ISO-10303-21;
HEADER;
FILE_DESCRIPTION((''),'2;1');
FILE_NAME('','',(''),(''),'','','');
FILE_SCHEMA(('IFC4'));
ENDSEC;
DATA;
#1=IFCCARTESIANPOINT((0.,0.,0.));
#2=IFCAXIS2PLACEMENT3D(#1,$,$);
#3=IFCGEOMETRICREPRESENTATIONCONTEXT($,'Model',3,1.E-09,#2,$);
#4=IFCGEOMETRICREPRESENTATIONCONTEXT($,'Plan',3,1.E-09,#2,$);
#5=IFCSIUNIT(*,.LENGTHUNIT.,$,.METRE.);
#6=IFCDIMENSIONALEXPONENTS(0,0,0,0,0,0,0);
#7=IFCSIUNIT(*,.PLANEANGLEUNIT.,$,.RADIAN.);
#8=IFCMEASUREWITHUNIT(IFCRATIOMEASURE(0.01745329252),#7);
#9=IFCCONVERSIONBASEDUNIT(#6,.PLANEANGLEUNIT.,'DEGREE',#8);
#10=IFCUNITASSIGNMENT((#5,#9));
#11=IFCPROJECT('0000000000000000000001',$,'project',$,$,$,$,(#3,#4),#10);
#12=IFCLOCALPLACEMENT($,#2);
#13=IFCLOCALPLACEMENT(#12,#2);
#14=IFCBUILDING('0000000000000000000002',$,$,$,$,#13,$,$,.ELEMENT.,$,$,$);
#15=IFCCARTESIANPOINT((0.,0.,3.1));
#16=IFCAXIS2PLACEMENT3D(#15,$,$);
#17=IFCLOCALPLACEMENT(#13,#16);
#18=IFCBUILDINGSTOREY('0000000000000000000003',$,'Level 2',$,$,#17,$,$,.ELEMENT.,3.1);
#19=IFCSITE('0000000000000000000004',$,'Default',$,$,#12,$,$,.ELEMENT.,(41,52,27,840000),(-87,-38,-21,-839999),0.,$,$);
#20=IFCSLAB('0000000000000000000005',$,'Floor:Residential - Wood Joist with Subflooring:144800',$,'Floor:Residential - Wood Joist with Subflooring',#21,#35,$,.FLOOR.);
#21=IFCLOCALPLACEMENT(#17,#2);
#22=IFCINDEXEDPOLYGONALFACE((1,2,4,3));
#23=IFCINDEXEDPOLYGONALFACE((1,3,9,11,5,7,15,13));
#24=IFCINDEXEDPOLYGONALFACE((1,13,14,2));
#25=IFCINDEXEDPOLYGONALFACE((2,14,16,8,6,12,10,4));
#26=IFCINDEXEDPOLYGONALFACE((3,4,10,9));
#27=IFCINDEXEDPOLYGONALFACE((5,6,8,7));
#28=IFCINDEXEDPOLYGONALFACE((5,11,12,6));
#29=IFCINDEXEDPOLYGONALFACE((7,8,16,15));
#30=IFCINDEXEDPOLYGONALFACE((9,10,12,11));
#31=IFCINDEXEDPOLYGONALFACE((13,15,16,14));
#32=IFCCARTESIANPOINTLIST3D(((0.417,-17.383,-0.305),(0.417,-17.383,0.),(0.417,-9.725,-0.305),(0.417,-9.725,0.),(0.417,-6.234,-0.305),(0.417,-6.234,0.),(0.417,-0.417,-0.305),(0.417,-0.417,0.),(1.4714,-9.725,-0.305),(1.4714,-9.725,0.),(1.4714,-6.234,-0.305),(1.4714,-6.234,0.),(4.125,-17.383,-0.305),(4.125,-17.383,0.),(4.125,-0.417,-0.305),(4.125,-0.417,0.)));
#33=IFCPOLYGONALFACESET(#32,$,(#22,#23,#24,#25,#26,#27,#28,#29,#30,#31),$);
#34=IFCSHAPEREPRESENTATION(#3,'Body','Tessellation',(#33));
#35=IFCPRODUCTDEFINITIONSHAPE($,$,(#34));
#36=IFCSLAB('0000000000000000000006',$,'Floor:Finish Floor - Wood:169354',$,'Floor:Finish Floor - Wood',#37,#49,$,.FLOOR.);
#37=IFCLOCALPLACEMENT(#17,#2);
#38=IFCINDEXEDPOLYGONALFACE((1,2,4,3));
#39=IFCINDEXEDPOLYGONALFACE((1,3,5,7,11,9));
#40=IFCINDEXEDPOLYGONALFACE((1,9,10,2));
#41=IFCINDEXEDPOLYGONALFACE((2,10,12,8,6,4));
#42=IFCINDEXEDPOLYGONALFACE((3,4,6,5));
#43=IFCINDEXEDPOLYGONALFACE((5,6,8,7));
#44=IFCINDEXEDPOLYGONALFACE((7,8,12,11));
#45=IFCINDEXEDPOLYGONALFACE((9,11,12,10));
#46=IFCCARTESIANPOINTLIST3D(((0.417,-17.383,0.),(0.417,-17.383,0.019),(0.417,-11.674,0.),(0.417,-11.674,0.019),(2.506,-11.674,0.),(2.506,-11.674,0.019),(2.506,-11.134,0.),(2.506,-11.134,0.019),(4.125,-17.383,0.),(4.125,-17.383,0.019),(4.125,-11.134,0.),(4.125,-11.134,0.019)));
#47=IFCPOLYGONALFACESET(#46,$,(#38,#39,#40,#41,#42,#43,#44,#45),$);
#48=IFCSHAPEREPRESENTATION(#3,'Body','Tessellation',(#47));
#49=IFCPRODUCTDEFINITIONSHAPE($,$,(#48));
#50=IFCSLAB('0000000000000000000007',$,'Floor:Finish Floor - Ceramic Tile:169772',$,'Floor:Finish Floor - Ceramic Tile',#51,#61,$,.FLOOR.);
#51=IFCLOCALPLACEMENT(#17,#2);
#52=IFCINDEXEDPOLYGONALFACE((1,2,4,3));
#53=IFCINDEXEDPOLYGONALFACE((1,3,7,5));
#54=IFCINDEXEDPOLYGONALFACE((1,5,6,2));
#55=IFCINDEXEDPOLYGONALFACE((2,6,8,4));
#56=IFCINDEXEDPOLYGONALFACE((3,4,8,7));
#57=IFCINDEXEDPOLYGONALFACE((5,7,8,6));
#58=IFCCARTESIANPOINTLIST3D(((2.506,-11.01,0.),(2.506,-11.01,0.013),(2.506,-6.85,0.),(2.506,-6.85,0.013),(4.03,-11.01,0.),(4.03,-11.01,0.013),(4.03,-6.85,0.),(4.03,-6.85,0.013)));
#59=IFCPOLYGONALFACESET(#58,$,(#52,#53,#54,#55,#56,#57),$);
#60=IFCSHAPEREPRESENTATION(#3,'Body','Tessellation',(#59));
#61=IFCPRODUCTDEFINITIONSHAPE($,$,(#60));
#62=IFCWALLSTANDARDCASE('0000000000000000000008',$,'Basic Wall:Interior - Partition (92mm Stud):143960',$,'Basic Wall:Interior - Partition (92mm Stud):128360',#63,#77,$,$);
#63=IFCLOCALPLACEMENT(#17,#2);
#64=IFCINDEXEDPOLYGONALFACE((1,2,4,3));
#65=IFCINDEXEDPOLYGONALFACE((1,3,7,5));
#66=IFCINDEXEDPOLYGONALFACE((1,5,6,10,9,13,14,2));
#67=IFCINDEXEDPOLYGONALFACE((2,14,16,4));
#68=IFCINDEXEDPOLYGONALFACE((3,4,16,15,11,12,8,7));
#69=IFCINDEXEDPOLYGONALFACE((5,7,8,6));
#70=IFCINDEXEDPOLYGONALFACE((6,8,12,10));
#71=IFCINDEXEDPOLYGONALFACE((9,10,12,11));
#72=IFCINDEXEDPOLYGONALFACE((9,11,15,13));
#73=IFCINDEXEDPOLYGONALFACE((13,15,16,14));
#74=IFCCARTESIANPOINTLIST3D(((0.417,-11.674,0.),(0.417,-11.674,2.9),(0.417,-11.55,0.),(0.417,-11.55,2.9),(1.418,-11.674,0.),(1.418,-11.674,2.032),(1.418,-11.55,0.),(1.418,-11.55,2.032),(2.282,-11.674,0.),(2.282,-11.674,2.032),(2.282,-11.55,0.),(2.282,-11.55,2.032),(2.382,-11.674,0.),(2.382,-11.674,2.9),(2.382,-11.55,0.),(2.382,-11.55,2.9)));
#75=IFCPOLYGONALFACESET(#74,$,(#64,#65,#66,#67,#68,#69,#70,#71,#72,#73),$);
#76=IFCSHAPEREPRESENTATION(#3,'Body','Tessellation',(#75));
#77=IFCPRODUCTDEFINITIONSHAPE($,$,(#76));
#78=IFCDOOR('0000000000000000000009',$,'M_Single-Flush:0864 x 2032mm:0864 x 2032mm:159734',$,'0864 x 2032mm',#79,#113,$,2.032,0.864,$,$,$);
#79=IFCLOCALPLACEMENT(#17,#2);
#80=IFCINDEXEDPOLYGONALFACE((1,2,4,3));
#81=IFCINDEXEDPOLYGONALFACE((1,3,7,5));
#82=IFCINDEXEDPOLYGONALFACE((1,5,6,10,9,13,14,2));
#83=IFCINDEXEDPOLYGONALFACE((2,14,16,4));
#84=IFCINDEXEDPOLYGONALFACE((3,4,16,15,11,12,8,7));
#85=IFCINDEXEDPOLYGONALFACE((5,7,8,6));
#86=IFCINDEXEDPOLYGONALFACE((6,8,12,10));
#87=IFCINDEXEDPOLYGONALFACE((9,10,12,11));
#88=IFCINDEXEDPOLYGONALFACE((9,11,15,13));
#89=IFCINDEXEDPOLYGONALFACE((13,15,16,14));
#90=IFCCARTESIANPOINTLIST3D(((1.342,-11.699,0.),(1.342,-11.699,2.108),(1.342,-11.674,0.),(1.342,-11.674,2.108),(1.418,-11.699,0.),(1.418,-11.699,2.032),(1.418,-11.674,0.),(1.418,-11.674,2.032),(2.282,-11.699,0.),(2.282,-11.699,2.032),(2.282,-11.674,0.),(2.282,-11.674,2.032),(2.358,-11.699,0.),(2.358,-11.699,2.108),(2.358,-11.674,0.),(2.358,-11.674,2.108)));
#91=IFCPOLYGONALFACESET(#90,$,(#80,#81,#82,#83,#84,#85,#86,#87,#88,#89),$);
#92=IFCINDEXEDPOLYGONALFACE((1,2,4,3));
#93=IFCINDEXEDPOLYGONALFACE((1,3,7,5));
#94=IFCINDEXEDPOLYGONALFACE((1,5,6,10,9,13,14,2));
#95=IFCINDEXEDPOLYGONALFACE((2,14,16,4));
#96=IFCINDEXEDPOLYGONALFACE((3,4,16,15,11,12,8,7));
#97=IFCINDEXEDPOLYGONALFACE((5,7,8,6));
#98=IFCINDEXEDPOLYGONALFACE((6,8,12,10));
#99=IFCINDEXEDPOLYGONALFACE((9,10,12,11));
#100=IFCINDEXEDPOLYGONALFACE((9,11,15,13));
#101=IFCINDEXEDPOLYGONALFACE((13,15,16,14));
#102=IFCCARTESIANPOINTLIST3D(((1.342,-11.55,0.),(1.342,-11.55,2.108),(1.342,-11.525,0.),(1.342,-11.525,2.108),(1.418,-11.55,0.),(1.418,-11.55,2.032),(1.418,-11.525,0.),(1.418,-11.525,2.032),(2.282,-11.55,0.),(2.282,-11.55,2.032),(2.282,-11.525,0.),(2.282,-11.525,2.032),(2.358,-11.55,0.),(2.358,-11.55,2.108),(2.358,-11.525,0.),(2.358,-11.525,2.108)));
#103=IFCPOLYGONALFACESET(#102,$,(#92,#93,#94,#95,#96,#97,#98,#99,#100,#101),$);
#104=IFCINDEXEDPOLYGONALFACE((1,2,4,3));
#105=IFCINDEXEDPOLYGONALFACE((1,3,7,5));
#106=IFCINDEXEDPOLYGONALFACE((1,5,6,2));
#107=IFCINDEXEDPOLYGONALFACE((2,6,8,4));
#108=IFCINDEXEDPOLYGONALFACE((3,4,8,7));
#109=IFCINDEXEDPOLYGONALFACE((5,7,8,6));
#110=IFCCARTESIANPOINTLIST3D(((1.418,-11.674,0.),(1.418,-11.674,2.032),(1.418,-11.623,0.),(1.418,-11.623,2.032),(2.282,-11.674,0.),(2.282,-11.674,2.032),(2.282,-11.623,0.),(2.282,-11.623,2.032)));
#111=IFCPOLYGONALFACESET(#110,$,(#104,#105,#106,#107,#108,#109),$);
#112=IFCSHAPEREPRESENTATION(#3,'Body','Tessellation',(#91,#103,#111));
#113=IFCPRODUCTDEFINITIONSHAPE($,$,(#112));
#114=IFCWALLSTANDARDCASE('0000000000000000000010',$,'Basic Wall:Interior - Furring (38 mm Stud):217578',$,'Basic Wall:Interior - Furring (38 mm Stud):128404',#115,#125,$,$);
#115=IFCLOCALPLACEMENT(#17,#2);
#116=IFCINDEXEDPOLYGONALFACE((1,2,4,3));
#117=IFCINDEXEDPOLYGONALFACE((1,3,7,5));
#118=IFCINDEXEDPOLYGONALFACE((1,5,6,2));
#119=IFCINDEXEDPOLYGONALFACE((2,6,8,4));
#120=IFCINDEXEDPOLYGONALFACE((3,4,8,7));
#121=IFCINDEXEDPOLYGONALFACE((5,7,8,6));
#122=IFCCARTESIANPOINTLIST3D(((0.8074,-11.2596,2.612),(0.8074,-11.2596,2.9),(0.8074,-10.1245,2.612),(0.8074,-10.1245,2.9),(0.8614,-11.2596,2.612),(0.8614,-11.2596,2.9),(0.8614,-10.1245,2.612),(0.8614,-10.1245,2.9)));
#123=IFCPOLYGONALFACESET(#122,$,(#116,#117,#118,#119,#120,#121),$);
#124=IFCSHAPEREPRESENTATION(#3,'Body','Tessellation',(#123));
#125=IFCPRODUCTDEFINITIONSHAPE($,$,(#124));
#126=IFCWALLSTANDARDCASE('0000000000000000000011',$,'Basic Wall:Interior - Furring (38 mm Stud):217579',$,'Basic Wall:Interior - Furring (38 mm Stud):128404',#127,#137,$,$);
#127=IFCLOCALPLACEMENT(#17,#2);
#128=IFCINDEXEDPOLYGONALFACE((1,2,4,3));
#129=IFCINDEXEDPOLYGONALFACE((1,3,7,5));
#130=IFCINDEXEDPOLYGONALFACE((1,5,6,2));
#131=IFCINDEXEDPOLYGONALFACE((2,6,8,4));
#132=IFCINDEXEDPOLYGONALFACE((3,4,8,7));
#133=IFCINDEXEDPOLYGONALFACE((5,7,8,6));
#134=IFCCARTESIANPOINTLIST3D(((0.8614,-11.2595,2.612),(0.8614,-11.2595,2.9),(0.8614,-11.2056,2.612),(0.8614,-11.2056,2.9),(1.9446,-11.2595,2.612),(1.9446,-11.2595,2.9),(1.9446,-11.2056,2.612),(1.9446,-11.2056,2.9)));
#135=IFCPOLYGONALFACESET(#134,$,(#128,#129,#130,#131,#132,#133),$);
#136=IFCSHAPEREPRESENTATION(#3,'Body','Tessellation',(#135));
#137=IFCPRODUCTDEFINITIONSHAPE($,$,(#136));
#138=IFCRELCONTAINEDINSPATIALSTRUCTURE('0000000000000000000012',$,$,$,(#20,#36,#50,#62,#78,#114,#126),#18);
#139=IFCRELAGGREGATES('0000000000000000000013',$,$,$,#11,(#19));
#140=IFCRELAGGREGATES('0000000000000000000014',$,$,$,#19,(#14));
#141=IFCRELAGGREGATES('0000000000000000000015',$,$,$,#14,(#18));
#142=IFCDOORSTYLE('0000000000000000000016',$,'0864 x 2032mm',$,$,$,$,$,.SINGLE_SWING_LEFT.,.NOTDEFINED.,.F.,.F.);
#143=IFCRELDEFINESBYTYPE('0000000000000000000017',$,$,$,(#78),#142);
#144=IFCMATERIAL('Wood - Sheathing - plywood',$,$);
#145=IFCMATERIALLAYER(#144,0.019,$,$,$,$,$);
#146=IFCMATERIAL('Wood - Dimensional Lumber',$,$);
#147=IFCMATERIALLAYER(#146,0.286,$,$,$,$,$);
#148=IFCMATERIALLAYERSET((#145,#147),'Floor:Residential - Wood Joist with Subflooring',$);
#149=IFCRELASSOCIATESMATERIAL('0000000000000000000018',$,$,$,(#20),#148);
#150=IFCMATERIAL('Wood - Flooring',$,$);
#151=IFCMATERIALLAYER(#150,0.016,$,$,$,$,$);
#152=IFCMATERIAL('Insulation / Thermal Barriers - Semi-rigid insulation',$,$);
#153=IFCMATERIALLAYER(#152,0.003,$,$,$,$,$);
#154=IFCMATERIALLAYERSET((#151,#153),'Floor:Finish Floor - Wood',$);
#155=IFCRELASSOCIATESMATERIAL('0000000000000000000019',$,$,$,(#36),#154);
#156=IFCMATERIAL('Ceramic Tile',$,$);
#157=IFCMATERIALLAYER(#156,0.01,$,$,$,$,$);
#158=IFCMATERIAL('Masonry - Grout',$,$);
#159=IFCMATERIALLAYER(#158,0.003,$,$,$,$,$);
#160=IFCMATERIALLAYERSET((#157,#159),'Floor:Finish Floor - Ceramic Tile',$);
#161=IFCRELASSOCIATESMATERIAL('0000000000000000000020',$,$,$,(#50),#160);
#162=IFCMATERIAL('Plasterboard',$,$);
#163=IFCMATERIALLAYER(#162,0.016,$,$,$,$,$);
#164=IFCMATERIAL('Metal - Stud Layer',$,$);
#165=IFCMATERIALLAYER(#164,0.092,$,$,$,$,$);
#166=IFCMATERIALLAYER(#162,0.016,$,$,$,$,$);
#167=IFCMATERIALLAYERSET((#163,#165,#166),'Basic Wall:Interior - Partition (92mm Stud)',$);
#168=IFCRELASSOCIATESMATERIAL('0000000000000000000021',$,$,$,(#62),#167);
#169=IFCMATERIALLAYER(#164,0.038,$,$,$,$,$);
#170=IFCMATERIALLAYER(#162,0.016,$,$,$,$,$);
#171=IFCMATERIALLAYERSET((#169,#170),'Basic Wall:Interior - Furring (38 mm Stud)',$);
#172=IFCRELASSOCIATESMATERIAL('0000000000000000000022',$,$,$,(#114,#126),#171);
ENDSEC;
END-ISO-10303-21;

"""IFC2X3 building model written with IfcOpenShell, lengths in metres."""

from ifc_helpers import new_model, entity, si_unit, converted_unit, frame, frame_2d, origin, origin_2d_with_axis, place, context, project, spatial, polyline, rectangle, outline, extrude, source, transform, mapped, material, layer, layer_set, layer_usage, type_object, type_shapes, element, fill, save


model = new_model("IFC2X3")

# Units and contexts
model_context = context("Model", 3, precision=1e-09, world=origin())
plan_context = context("Plan", 3, precision=1e-09, world=origin())
ifc_project = project(units=[si_unit("LENGTHUNIT", "METRE"), converted_unit("PLANEANGLEUNIT", "DEGREE", entity("IfcRatioMeasure", 0.01745329252), si_unit("PLANEANGLEUNIT", "RADIAN"), dimensions=[0, 0, 0, 0, 0, 0, 0])], contexts=[model_context, plan_context])

# Site, building, storey
site_placement = place(None, origin())
site = spatial("IfcSite", under=ifc_project, at=site_placement, Name="Default", CompositionType="ELEMENT", RefLatitude=(41, 52, 27, 840000), RefLongitude=(-87, -38, -21, -839999), RefElevation=0.0)
building_placement = place(site_placement, origin())
building = spatial("IfcBuilding", under=site, at=building_placement, CompositionType="ELEMENT")
storey_placement = place(building_placement, frame((0.0, 0.0, 3.1)))
storey = spatial("IfcBuildingStorey", under=building, at=storey_placement, Name="Level 2", CompositionType="ELEMENT", Elevation=3.1)

# Slabs
ifc_material_1 = material(Name="Wood - Sheathing - plywood")
ifc_layer_1 = layer(ifc_material_1, 0.019)
ifc_material_2 = material(Name="Wood - Dimensional Lumber")
ifc_layer_2 = layer(ifc_material_2, 0.286)
ifc_layer_set_1 = layer_set([ifc_layer_1, ifc_layer_2], Name="Floor:Residential - Wood Joist with Subflooring")
ifc_layer_usage_1 = layer_usage(ifc_layer_set_1, "AXIS3", "POSITIVE", 0.0)
slab_1_placement = place(storey_placement, frame((0.417, -17.383, -0.305)))
element("IfcSlab", 1, at=slab_1_placement, inside=storey, material=ifc_layer_usage_1, Name="Floor:Residential - Wood Joist with Subflooring:144800", ObjectType="Floor:Residential - Wood Joist with Subflooring", PredefinedType="FLOOR", context=model_context, shape_type="SweptSolid", body=[
    extrude(outline(polyline([(-1.854, 8.483), (-1.854, -8.483), (1.854, -8.483), (1.854, -0.825), (0.7996, -0.825), (0.7996, 2.666), (1.854, 2.666), (1.854, 8.483), (-1.854, 8.483)])), frame((1.854, 8.483, 0.305), z_axis=(0.0, 0.0, -1.0), x_axis=(-1.0, 0.0, 0.0)), (0.0, 0.0, 1.0), 0.305),
])
ifc_material_3 = material(Name="Wood - Flooring")
ifc_layer_3 = layer(ifc_material_3, 0.016)
ifc_material_4 = material(Name="Insulation / Thermal Barriers - Semi-rigid insulation")
ifc_layer_4 = layer(ifc_material_4, 0.003)
ifc_layer_set_2 = layer_set([ifc_layer_3, ifc_layer_4], Name="Floor:Finish Floor - Wood")
ifc_layer_usage_2 = layer_usage(ifc_layer_set_2, "AXIS3", "POSITIVE", 0.0)
slab_2_placement = place(storey_placement, frame((0.417, -17.383, 0.0)))
element("IfcSlab", 2, at=slab_2_placement, inside=storey, material=ifc_layer_usage_2, Name="Floor:Finish Floor - Wood:169354", ObjectType="Floor:Finish Floor - Wood", PredefinedType="FLOOR", context=model_context, shape_type="SweptSolid", body=[
    extrude(outline(polyline([(-1.854, -3.1245), (1.854, -3.1245), (1.854, 2.5845), (-0.235, 2.5845), (-0.235, 3.1245), (-1.854, 3.1245), (-1.854, -3.1245)])), frame((1.854, 3.1245, 0.019), z_axis=(0.0, 0.0, -1.0), x_axis=(-1.0, 0.0, 0.0)), (0.0, 0.0, 1.0), 0.019),
])
ifc_material_5 = material(Name="Ceramic Tile")
ifc_layer_5 = layer(ifc_material_5, 0.01)
ifc_material_6 = material(Name="Masonry - Grout")
ifc_layer_6 = layer(ifc_material_6, 0.003)
ifc_layer_set_3 = layer_set([ifc_layer_5, ifc_layer_6], Name="Floor:Finish Floor - Ceramic Tile")
ifc_layer_usage_3 = layer_usage(ifc_layer_set_3, "AXIS3", "POSITIVE", 0.0)
slab_3_placement = place(storey_placement, frame((2.506, -11.01, 0.0)))
element("IfcSlab", 3, at=slab_3_placement, inside=storey, material=ifc_layer_usage_3, Name="Floor:Finish Floor - Ceramic Tile:169772", ObjectType="Floor:Finish Floor - Ceramic Tile", PredefinedType="FLOOR", context=model_context, shape_type="SweptSolid", body=[
    extrude(rectangle(XDim=4.16, YDim=1.524, at=frame_2d((0.0, 0.0), x_axis=(0.0, -1.0))), frame((0.762, 2.08, 0.013), z_axis=(0.0, 0.0, -1.0), x_axis=(-1.0, 0.0, 0.0)), (0.0, 0.0, 1.0), 0.013),
])

# Shared definitions
ifc_material_7 = material(Name="Metal - Stud Layer")
ifc_material_8 = material(Name="Plasterboard")

# Wall, opening, door
ifc_layer_7 = layer(ifc_material_8, 0.016)
ifc_layer_8 = layer(ifc_material_7, 0.092)
ifc_layer_9 = layer(ifc_material_8, 0.016)
ifc_layer_set_4 = layer_set([ifc_layer_7, ifc_layer_8, ifc_layer_9], Name="Basic Wall:Interior - Partition (92mm Stud)")
ifc_layer_usage_4 = layer_usage(ifc_layer_set_4, "AXIS2", "NEGATIVE", 0.062)
wall_1_placement = place(storey_placement, frame((2.382, -11.612, 0.0), z_axis=(0.0, 0.0, 1.0), x_axis=(-1.0, 0.0, 0.0)))
wall_1 = element("IfcWallStandardCase", 4, at=wall_1_placement, inside=storey, material=ifc_layer_usage_4, Name="Basic Wall:Interior - Partition (92mm Stud):143960", ObjectType="Basic Wall:Interior - Partition (92mm Stud):128360", context=model_context, shape_type="SweptSolid", body=[
    extrude(rectangle(XDim=1.965, YDim=0.124, at=frame_2d((0.9825, 0.0), x_axis=(-1.0, 0.0))), origin(), (0.0, 0.0, 1.0), 2.9),
])
opening_1_placement = place(wall_1_placement, frame((0.1, -0.062, 0.0)))
opening_1 = element("IfcOpeningElement", 5, at=opening_1_placement, cuts=wall_1, ObjectType="Opening", context=model_context, shape_type="SweptSolid", body=[
    extrude(rectangle(XDim=0.864, YDim=2.032, at=frame_2d((1.016, 0.432), x_axis=(0.0, -1.0))), frame((0.0, 0.0, 0.0), z_axis=(0.0, 1.0, 0.0), x_axis=(0.0, 0.0, 1.0)), (0.0, 0.0, 1.0), 0.124),
])
door_style = type_object("IfcDoorStyle", Name="0864 x 2032mm", ConstructionType="NOTDEFINED", OperationType="SINGLE_SWING_LEFT", ParameterTakesPrecedence=False, Sizeable=False)
shared_shape_1 = source(origin(), model_context, "Body", "SweptSolid", [
    extrude(outline(polyline([(-0.508, -1.073), (0.508, -1.073), (0.508, 1.035), (0.432, 1.035), (0.432, -0.997), (-0.432, -0.997), (-0.432, 1.035), (-0.508, 1.035), (-0.508, -1.073)])), frame((0.432, 0.149, 1.035), z_axis=(0.0, -1.0, 0.0), x_axis=(-1.0, 0.0, 0.0)), (0.0, 0.0, 1.0), 0.025),
    extrude(outline(polyline([(-1.073, -0.508), (1.035, -0.508), (1.035, -0.432), (-0.997, -0.432), (-0.997, 0.432), (1.035, 0.432), (1.035, 0.508), (-1.073, 0.508), (-1.073, -0.508)])), frame((0.432, 0.0, 1.035), z_axis=(0.0, -1.0, 0.0), x_axis=(0.0, 0.0, -1.0)), (0.0, 0.0, 1.0), 0.025),
    extrude(rectangle(XDim=0.864, YDim=0.051, at=origin_2d_with_axis()), frame((0.432, 0.0985, 0.0)), (0.0, 0.0, 1.0), 2.032),
])
type_shapes(door_style, [shared_shape_1])
door_placement = place(opening_1_placement, origin())
door = element("IfcDoor", 6, at=door_placement, inside=storey, type_object=door_style, Name="M_Single-Flush:0864 x 2032mm:0864 x 2032mm:159734", ObjectType="0864 x 2032mm", OverallHeight=2.032, OverallWidth=0.864, context=model_context, shape_type="MappedRepresentation", body=[
    mapped(shared_shape_1, transform((0.0, 0.0, 0.0), scale=1.0)),
])
fill(opening_1, door)

# Walls
ifc_layer_10 = layer(ifc_material_7, 0.038)
ifc_layer_11 = layer(ifc_material_8, 0.016)
ifc_layer_set_5 = layer_set([ifc_layer_10, ifc_layer_11], Name="Basic Wall:Interior - Furring (38 mm Stud)")
ifc_layer_usage_5 = layer_usage(ifc_layer_set_5, "AXIS2", "NEGATIVE", 0.027)
wall_2_placement = place(storey_placement, frame((0.8345, -11.2596, 2.612), z_axis=(0.0, 0.0, 1.0), x_axis=(0.0, 1.0, 0.0)))
element("IfcWallStandardCase", 7, at=wall_2_placement, inside=storey, material=ifc_layer_usage_5, Name="Basic Wall:Interior - Furring (38 mm Stud):217578", ObjectType="Basic Wall:Interior - Furring (38 mm Stud):128404", context=model_context, shape_type="SweptSolid", body=[
    extrude(rectangle(XDim=1.1351, YDim=0.054, at=frame_2d((0.5675, 0.0), x_axis=(-1.0, 0.0))), origin(), (0.0, 0.0, 1.0), 0.288),
])
ifc_layer_usage_6 = layer_usage(ifc_layer_set_5, "AXIS2", "NEGATIVE", 0.027)
wall_3_placement = place(storey_placement, frame((1.9446, -11.2325, 2.612), z_axis=(0.0, 0.0, 1.0), x_axis=(-1.0, 0.0, 0.0)))
element("IfcWallStandardCase", 8, at=wall_3_placement, inside=storey, material=ifc_layer_usage_6, Name="Basic Wall:Interior - Furring (38 mm Stud):217579", ObjectType="Basic Wall:Interior - Furring (38 mm Stud):128404", context=model_context, shape_type="SweptSolid", body=[
    extrude(rectangle(XDim=1.0831, YDim=0.054, at=frame_2d((0.5415, 0.0), x_axis=(-1.0, 0.0))), origin(), (0.0, 0.0, 1.0), 0.288),
])

save(model, "model.ifc")
